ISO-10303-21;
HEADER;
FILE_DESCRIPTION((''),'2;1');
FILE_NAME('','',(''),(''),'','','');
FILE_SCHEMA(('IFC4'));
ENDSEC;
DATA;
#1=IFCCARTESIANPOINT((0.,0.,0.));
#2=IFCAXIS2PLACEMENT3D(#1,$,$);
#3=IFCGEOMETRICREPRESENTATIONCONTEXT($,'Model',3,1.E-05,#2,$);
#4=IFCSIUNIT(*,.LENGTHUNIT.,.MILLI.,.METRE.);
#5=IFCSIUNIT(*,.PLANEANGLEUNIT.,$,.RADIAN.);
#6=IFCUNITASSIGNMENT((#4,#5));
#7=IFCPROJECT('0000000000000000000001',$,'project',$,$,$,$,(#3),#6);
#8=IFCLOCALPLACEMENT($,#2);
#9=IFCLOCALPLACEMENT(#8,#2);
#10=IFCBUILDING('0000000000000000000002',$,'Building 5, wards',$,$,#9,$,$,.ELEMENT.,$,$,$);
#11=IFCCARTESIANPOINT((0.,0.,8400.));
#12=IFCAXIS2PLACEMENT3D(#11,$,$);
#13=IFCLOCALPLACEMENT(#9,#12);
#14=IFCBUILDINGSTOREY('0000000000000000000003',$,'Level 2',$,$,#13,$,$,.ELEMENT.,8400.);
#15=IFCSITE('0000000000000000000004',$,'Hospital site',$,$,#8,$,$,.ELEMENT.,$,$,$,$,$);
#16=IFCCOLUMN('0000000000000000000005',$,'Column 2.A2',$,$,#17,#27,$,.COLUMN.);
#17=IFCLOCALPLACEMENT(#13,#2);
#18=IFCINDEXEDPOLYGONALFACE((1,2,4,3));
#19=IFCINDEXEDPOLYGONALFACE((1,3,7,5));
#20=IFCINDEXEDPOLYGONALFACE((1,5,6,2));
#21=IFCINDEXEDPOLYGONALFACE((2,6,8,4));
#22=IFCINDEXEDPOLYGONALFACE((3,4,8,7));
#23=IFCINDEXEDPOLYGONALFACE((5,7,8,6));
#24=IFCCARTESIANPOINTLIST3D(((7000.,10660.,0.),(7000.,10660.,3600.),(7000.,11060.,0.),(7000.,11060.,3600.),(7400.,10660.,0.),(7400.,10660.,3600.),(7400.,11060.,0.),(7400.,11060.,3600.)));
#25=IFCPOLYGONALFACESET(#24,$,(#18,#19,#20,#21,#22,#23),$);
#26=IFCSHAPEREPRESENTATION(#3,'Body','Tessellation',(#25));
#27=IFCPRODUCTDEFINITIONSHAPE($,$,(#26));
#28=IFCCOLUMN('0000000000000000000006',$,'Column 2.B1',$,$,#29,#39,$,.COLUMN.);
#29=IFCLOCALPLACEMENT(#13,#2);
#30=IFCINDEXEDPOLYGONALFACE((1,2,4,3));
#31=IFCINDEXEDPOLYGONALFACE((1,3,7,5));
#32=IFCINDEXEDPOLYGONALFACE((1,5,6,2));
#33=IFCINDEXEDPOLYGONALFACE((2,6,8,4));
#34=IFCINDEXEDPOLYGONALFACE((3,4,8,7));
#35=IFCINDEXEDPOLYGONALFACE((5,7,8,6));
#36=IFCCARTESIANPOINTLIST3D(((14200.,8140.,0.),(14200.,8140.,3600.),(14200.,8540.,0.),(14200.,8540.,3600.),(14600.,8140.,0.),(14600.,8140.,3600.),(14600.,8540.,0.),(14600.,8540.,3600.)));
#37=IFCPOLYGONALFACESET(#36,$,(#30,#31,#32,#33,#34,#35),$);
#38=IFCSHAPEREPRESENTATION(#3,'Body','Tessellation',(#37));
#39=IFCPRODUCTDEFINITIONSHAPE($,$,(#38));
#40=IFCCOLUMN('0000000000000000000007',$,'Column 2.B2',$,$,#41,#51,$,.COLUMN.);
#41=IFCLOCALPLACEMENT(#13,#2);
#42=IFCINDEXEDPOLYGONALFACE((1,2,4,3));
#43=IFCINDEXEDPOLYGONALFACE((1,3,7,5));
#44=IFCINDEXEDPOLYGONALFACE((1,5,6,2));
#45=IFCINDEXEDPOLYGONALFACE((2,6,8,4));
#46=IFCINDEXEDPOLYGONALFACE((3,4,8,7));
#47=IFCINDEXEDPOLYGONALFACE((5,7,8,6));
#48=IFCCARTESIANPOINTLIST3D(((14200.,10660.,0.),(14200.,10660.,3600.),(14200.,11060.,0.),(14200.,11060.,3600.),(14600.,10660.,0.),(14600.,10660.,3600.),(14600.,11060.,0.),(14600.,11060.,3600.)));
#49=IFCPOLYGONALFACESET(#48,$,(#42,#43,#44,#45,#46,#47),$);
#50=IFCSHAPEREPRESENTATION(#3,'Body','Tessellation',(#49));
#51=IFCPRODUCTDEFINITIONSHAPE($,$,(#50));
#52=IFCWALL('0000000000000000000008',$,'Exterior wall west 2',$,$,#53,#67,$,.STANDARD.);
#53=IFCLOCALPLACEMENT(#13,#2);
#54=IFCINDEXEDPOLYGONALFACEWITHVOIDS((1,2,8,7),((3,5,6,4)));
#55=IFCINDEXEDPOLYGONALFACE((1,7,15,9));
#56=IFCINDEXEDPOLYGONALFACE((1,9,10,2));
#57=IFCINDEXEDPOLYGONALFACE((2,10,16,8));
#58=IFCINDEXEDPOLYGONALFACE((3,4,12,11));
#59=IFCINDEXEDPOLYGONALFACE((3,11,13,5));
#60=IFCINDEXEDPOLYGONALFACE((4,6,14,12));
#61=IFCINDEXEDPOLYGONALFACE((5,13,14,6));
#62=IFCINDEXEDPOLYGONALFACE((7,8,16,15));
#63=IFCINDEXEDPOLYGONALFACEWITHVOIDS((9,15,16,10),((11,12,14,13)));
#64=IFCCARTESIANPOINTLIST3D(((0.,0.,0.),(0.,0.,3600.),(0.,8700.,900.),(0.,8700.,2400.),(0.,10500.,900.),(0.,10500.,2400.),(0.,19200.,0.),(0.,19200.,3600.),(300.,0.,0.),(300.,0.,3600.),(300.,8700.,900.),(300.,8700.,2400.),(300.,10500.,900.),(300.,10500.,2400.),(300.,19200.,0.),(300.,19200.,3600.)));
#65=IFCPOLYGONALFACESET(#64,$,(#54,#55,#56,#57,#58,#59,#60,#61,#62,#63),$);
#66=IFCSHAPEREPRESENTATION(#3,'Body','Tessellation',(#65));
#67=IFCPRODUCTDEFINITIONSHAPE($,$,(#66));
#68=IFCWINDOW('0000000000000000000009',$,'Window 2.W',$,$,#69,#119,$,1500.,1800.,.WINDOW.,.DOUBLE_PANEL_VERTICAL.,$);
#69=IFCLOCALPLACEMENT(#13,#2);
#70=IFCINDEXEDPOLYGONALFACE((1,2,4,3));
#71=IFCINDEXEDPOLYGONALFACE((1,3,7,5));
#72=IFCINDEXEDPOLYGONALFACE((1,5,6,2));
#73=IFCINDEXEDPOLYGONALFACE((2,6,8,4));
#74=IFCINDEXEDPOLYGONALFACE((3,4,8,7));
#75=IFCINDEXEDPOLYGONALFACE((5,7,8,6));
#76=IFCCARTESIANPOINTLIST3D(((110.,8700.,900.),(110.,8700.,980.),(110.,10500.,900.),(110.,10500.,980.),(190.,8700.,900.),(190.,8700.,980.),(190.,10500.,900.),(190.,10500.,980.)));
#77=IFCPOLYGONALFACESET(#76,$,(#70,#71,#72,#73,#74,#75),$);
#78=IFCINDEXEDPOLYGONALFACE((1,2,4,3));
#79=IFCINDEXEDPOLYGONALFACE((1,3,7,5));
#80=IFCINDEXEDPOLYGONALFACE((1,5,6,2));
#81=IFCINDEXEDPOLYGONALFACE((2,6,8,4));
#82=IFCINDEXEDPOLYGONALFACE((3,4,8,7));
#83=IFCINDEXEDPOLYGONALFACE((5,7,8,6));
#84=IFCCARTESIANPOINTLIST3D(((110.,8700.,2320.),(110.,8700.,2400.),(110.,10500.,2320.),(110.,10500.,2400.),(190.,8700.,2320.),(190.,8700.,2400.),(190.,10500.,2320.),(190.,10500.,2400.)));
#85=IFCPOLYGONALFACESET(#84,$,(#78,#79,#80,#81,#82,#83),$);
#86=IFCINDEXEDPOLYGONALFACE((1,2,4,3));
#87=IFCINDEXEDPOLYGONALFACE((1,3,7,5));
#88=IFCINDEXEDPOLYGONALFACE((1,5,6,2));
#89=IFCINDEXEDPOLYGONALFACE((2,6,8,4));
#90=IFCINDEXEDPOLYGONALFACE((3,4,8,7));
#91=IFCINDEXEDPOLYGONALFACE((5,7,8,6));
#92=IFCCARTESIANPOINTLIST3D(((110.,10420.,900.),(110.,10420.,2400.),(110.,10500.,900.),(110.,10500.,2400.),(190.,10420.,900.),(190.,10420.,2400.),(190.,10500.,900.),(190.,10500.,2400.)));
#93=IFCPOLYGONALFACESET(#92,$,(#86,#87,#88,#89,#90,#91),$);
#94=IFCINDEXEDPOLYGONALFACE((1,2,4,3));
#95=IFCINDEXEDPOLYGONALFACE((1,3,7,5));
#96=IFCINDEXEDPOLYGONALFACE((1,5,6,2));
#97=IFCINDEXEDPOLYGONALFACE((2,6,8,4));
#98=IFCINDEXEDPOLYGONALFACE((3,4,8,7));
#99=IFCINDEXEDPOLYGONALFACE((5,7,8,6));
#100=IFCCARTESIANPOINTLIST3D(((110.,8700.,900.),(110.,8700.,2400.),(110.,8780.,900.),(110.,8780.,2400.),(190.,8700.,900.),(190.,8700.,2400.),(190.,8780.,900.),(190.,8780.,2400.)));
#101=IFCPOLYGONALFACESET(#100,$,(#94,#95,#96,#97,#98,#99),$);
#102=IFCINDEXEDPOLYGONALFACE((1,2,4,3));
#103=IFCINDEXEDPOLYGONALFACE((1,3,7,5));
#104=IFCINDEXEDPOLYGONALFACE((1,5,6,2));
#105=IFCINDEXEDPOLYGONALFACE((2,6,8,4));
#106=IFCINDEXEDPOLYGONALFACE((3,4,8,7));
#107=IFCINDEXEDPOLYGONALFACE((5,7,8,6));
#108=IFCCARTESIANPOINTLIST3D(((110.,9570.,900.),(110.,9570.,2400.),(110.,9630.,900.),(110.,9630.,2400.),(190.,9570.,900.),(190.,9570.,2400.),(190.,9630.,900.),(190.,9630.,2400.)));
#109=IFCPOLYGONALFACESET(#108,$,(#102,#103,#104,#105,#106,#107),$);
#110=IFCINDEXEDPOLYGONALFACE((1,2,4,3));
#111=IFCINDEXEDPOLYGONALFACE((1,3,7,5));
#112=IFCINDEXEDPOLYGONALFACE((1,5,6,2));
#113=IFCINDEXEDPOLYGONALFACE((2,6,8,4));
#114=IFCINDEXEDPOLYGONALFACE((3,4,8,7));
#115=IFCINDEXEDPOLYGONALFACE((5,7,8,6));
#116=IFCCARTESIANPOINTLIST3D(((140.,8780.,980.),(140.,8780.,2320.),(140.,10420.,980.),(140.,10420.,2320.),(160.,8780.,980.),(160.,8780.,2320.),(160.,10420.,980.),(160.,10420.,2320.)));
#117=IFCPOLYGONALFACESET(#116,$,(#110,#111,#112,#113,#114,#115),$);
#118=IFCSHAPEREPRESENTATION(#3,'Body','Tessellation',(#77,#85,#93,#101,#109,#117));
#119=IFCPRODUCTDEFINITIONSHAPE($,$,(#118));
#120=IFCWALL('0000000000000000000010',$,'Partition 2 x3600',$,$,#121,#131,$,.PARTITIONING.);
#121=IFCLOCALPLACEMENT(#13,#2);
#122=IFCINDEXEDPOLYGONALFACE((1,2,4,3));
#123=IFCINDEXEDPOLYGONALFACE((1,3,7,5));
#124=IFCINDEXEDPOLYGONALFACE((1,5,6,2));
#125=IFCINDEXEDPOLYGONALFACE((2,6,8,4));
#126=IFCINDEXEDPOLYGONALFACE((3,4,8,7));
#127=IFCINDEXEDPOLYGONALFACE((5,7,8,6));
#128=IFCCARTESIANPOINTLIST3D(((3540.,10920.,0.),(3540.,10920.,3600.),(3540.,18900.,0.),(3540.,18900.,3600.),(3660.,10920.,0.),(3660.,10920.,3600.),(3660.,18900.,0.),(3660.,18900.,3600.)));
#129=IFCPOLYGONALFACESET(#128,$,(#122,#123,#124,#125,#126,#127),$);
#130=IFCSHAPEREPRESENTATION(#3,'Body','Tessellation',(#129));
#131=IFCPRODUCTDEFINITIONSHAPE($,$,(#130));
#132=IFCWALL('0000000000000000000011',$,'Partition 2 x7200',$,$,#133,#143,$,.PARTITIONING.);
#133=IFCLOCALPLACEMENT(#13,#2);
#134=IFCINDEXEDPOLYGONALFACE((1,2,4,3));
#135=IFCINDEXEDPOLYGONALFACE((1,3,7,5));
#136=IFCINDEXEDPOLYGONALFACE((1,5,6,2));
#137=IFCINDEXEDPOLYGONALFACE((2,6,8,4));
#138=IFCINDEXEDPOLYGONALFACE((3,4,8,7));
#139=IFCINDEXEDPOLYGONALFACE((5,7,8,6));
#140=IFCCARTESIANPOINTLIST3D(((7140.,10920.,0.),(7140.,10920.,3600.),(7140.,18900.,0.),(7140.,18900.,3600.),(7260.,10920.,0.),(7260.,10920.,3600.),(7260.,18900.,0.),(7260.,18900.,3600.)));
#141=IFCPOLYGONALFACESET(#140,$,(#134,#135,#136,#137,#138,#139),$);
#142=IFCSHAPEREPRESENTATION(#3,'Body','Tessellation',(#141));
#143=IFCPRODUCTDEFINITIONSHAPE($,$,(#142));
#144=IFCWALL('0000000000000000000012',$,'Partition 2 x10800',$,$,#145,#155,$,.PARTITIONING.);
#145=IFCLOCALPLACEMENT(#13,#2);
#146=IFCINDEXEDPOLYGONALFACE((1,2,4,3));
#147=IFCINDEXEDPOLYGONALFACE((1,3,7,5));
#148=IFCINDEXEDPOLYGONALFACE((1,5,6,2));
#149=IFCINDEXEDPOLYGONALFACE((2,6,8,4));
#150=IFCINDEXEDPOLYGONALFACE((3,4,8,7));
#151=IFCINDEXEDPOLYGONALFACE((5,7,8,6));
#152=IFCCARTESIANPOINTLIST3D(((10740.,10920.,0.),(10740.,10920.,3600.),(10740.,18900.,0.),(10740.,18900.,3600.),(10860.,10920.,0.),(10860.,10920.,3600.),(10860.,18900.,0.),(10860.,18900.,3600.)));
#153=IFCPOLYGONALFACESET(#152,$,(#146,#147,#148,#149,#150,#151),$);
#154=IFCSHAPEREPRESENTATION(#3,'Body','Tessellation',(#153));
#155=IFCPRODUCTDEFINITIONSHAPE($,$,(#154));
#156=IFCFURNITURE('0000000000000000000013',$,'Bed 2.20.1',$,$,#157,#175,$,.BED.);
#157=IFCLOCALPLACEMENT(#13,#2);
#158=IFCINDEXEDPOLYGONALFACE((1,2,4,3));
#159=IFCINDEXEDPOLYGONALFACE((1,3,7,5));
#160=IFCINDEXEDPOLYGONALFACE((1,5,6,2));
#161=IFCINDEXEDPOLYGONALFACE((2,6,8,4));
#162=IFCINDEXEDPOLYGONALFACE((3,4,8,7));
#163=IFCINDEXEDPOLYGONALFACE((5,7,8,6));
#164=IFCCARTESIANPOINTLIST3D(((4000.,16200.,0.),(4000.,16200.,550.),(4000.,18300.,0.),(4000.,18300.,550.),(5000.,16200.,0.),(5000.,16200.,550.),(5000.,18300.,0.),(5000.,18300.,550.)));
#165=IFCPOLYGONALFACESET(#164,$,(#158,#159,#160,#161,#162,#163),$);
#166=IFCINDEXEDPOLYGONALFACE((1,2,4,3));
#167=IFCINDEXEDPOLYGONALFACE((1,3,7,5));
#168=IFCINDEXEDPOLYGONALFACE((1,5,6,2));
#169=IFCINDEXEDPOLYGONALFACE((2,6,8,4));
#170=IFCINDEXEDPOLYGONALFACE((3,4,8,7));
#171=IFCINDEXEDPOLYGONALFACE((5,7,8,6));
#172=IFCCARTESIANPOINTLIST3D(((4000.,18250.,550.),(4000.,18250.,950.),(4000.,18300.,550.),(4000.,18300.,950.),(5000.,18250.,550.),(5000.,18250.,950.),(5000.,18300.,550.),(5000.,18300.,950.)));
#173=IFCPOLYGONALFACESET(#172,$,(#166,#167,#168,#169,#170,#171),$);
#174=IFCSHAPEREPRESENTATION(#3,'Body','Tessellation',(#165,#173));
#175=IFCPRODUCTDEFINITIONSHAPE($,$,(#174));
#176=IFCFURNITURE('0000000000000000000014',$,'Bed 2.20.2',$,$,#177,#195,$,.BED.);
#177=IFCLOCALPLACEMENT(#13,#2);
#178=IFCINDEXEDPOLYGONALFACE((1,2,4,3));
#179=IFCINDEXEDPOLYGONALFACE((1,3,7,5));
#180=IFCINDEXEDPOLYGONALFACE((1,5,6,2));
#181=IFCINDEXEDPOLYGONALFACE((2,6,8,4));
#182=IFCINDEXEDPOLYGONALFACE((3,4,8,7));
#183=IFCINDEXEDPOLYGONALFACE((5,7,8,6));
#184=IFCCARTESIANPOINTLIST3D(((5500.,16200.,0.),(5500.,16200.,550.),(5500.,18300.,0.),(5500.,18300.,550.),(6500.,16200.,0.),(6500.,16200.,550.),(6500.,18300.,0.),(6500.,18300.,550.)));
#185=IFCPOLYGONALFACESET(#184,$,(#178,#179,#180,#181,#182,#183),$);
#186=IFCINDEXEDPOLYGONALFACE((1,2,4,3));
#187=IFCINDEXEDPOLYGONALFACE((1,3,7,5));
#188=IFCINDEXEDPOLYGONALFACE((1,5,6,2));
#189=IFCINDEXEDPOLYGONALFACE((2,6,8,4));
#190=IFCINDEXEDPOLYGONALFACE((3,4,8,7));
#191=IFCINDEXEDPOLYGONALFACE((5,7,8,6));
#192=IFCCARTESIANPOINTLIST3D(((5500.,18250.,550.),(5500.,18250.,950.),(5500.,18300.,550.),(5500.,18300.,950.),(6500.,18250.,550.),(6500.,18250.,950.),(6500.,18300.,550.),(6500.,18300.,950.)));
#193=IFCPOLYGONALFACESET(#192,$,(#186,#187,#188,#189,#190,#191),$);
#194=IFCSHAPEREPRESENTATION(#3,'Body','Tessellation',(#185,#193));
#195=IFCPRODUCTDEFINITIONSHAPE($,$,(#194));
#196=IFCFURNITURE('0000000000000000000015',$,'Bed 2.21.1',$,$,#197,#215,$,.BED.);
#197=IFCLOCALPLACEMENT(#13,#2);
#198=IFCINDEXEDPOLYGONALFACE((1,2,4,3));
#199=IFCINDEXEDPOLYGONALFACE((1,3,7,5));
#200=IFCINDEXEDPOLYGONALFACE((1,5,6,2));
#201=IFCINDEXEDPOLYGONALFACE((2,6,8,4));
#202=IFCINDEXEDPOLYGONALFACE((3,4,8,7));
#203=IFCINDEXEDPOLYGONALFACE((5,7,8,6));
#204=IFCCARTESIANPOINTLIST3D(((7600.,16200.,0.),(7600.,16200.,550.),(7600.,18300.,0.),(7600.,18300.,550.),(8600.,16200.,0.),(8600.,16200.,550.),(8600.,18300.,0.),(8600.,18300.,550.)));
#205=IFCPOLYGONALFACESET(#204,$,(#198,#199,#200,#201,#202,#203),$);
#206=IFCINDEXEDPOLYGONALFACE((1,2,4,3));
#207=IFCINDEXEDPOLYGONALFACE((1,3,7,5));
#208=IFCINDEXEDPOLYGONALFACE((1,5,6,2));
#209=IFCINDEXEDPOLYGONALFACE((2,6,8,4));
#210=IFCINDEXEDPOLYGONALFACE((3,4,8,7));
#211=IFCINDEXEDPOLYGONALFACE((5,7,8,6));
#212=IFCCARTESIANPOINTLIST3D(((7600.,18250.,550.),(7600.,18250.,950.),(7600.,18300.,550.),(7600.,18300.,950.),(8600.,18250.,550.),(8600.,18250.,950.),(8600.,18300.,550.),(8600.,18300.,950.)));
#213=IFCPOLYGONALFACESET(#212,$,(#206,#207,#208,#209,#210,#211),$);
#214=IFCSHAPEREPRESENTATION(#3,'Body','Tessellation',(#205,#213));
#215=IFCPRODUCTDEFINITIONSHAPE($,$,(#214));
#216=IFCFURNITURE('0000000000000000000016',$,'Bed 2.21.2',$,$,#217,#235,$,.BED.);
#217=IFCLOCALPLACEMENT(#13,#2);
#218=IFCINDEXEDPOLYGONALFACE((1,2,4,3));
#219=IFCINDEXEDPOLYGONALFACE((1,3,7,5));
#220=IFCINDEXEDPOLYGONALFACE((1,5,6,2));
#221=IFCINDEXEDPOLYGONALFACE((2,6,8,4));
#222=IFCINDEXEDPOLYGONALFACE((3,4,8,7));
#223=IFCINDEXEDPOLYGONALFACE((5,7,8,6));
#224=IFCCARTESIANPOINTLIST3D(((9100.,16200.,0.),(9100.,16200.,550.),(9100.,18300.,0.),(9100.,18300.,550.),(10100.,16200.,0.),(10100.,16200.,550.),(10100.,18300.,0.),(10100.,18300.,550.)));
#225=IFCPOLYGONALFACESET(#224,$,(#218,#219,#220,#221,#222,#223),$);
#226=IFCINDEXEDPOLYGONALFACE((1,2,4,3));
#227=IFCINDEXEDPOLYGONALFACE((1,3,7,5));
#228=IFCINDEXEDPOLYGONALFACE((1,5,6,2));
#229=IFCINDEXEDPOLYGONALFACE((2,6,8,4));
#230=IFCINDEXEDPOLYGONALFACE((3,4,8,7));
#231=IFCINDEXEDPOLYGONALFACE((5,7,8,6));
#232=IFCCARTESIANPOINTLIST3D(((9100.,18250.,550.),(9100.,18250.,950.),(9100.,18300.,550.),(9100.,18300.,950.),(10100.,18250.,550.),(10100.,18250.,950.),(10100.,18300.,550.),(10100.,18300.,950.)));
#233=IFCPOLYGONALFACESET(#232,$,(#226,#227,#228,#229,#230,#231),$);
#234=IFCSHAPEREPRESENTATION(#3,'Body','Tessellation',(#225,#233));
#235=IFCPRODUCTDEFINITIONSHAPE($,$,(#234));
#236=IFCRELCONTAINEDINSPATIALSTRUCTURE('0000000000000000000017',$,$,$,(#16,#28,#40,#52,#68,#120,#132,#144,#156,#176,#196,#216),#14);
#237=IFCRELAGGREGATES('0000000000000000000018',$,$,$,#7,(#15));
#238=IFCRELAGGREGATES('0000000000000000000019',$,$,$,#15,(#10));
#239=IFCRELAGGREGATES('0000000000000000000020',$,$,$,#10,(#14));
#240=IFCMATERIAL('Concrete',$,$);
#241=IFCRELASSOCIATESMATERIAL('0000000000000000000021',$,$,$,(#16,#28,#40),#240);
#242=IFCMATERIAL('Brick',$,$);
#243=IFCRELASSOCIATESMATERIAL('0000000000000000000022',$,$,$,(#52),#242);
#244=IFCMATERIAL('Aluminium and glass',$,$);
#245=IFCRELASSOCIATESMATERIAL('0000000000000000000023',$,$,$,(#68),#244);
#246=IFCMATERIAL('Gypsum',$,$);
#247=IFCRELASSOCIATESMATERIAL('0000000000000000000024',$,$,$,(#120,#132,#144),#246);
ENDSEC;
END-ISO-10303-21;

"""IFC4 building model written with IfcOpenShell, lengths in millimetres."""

from ifc_helpers import new_model, si_unit, frame, frame_2d, origin, origin_2d, place, context, project, spatial, rectangle, extrude, material, element, fill, save


model = new_model("IFC4")

# Units and contexts
model_context = context("Model", 3, precision=1e-05, world=origin())
ifc_project = project(units=[si_unit("LENGTHUNIT", "METRE", prefix="MILLI"), si_unit("PLANEANGLEUNIT", "RADIAN")], contexts=[model_context])

# Site, building, storey
site_placement = place(None, origin())
site = spatial("IfcSite", under=ifc_project, at=site_placement, Name="Hospital site", CompositionType="ELEMENT")
building_placement = place(site_placement, origin())
building = spatial("IfcBuilding", under=site, at=building_placement, Name="Building 5, wards", CompositionType="ELEMENT")
storey_placement = place(building_placement, frame((0.0, 0.0, 8400.0)))
storey = spatial("IfcBuildingStorey", under=building, at=storey_placement, Name="Level 2", CompositionType="ELEMENT", Elevation=8400.0)

# Columns
ifc_material_1 = material(Name="Concrete")
for number, where, name in (
    (1, (7200.0, 10860.0, 0.0), "Column 2.A2"),
    (2, (14400.0, 8340.0, 0.0), "Column 2.B1"),
    (3, (14400.0, 10860.0, 0.0), "Column 2.B2"),
):
    element("IfcColumn", number, at=place(storey_placement, frame(where)), inside=storey, material=ifc_material_1, Name=name, PredefinedType="COLUMN", context=model_context, shape_type="SweptSolid", body=[
        extrude(rectangle(XDim=400.0, YDim=400.0, at=origin_2d()), origin(), (0.0, 0.0, 1.0), 3600.0),
    ])

# Wall, opening, window
ifc_material_2 = material(Name="Brick")
wall_placement = place(storey_placement, frame((0.0, 19200.0, 0.0), x_axis=(0.0, -1.0, 0.0)))
wall = element("IfcWall", 4, at=wall_placement, inside=storey, material=ifc_material_2, Name="Exterior wall west 2", PredefinedType="STANDARD", context=model_context, shape_type="SweptSolid", body=[
    extrude(rectangle(XDim=19200.0, YDim=300.0, at=frame_2d((9600.0, 150.0))), origin(), (0.0, 0.0, 1.0), 3600.0),
])
opening_placement = place(wall_placement, frame((8700.0, -50.0, 900.0)))
opening = element("IfcOpeningElement", 5, at=opening_placement, cuts=wall, PredefinedType="OPENING", context=model_context, shape_type="SweptSolid", body=[
    extrude(rectangle(XDim=1800.0, YDim=400.0, at=frame_2d((900.0, 200.0))), origin(), (0.0, 0.0, 1.0), 1500.0),
])
ifc_material_3 = material(Name="Aluminium and glass")
window_placement = place(opening_placement, frame((0.0, 160.0, 0.0)))
window = element("IfcWindow", 6, at=window_placement, inside=storey, material=ifc_material_3, Name="Window 2.W", OverallHeight=1500.0, OverallWidth=1800.0, PartitioningType="DOUBLE_PANEL_VERTICAL", PredefinedType="WINDOW", context=model_context, shape_type="SweptSolid", body=[
    extrude(rectangle(XDim=1800.0, YDim=80.0, at=frame_2d((900.0, 40.0))), origin(), (0.0, 0.0, 1.0), 80.0),
    extrude(rectangle(XDim=1800.0, YDim=80.0, at=frame_2d((900.0, 40.0))), frame((0.0, 0.0, 1420.0)), (0.0, 0.0, 1.0), 80.0),
    extrude(rectangle(XDim=80.0, YDim=80.0, at=frame_2d((40.0, 40.0))), origin(), (0.0, 0.0, 1.0), 1500.0),
    extrude(rectangle(XDim=80.0, YDim=80.0, at=frame_2d((1760.0, 40.0))), origin(), (0.0, 0.0, 1.0), 1500.0),
    extrude(rectangle(XDim=60.0, YDim=80.0, at=frame_2d((900.0, 40.0))), origin(), (0.0, 0.0, 1.0), 1500.0),
    extrude(rectangle(XDim=1640.0, YDim=20.0, at=frame_2d((900.0, 40.0))), frame((0.0, 0.0, 80.0)), (0.0, 0.0, 1.0), 1340.0),
])
fill(opening, window)

# Walls
ifc_material_4 = material(Name="Gypsum")
for number, where, x_axis, name in (
    (7, (3660.0, 10920.0, 0.0), (0.0, 1.0, 0.0), "Partition 2 x3600"),
    (8, (7260.0, 10920.0, 0.0), (0.0, 1.0, 0.0), "Partition 2 x7200"),
    (9, (10860.0, 10920.0, 0.0), (0.0, 1.0, 0.0), "Partition 2 x10800"),
):
    element("IfcWall", number, at=place(storey_placement, frame(where, x_axis=x_axis)), inside=storey, material=ifc_material_4, Name=name, PredefinedType="PARTITIONING", context=model_context, shape_type="SweptSolid", body=[
        extrude(rectangle(XDim=7980.0, YDim=120.0, at=frame_2d((3990.0, 60.0))), origin(), (0.0, 0.0, 1.0), 3600.0),
    ])

# Furniture
for number, where, name in (
    (10, (4000.0, 16200.0, 0.0), "Bed 2.20.1"),
    (11, (5500.0, 16200.0, 0.0), "Bed 2.20.2"),
    (12, (7600.0, 16200.0, 0.0), "Bed 2.21.1"),
    (13, (9100.0, 16200.0, 0.0), "Bed 2.21.2"),
):
    element("IfcFurniture", number, at=place(storey_placement, frame(where)), inside=storey, Name=name, PredefinedType="BED", context=model_context, shape_type="SweptSolid", body=[
        extrude(rectangle(XDim=1000.0, YDim=2100.0, at=frame_2d((500.0, 1050.0))), origin(), (0.0, 0.0, 1.0), 550.0),
        extrude(rectangle(XDim=1000.0, YDim=50.0, at=frame_2d((500.0, 2075.0))), frame((0.0, 0.0, 550.0)), (0.0, 0.0, 1.0), 400.0),
    ])

save(model, "model.ifc")
